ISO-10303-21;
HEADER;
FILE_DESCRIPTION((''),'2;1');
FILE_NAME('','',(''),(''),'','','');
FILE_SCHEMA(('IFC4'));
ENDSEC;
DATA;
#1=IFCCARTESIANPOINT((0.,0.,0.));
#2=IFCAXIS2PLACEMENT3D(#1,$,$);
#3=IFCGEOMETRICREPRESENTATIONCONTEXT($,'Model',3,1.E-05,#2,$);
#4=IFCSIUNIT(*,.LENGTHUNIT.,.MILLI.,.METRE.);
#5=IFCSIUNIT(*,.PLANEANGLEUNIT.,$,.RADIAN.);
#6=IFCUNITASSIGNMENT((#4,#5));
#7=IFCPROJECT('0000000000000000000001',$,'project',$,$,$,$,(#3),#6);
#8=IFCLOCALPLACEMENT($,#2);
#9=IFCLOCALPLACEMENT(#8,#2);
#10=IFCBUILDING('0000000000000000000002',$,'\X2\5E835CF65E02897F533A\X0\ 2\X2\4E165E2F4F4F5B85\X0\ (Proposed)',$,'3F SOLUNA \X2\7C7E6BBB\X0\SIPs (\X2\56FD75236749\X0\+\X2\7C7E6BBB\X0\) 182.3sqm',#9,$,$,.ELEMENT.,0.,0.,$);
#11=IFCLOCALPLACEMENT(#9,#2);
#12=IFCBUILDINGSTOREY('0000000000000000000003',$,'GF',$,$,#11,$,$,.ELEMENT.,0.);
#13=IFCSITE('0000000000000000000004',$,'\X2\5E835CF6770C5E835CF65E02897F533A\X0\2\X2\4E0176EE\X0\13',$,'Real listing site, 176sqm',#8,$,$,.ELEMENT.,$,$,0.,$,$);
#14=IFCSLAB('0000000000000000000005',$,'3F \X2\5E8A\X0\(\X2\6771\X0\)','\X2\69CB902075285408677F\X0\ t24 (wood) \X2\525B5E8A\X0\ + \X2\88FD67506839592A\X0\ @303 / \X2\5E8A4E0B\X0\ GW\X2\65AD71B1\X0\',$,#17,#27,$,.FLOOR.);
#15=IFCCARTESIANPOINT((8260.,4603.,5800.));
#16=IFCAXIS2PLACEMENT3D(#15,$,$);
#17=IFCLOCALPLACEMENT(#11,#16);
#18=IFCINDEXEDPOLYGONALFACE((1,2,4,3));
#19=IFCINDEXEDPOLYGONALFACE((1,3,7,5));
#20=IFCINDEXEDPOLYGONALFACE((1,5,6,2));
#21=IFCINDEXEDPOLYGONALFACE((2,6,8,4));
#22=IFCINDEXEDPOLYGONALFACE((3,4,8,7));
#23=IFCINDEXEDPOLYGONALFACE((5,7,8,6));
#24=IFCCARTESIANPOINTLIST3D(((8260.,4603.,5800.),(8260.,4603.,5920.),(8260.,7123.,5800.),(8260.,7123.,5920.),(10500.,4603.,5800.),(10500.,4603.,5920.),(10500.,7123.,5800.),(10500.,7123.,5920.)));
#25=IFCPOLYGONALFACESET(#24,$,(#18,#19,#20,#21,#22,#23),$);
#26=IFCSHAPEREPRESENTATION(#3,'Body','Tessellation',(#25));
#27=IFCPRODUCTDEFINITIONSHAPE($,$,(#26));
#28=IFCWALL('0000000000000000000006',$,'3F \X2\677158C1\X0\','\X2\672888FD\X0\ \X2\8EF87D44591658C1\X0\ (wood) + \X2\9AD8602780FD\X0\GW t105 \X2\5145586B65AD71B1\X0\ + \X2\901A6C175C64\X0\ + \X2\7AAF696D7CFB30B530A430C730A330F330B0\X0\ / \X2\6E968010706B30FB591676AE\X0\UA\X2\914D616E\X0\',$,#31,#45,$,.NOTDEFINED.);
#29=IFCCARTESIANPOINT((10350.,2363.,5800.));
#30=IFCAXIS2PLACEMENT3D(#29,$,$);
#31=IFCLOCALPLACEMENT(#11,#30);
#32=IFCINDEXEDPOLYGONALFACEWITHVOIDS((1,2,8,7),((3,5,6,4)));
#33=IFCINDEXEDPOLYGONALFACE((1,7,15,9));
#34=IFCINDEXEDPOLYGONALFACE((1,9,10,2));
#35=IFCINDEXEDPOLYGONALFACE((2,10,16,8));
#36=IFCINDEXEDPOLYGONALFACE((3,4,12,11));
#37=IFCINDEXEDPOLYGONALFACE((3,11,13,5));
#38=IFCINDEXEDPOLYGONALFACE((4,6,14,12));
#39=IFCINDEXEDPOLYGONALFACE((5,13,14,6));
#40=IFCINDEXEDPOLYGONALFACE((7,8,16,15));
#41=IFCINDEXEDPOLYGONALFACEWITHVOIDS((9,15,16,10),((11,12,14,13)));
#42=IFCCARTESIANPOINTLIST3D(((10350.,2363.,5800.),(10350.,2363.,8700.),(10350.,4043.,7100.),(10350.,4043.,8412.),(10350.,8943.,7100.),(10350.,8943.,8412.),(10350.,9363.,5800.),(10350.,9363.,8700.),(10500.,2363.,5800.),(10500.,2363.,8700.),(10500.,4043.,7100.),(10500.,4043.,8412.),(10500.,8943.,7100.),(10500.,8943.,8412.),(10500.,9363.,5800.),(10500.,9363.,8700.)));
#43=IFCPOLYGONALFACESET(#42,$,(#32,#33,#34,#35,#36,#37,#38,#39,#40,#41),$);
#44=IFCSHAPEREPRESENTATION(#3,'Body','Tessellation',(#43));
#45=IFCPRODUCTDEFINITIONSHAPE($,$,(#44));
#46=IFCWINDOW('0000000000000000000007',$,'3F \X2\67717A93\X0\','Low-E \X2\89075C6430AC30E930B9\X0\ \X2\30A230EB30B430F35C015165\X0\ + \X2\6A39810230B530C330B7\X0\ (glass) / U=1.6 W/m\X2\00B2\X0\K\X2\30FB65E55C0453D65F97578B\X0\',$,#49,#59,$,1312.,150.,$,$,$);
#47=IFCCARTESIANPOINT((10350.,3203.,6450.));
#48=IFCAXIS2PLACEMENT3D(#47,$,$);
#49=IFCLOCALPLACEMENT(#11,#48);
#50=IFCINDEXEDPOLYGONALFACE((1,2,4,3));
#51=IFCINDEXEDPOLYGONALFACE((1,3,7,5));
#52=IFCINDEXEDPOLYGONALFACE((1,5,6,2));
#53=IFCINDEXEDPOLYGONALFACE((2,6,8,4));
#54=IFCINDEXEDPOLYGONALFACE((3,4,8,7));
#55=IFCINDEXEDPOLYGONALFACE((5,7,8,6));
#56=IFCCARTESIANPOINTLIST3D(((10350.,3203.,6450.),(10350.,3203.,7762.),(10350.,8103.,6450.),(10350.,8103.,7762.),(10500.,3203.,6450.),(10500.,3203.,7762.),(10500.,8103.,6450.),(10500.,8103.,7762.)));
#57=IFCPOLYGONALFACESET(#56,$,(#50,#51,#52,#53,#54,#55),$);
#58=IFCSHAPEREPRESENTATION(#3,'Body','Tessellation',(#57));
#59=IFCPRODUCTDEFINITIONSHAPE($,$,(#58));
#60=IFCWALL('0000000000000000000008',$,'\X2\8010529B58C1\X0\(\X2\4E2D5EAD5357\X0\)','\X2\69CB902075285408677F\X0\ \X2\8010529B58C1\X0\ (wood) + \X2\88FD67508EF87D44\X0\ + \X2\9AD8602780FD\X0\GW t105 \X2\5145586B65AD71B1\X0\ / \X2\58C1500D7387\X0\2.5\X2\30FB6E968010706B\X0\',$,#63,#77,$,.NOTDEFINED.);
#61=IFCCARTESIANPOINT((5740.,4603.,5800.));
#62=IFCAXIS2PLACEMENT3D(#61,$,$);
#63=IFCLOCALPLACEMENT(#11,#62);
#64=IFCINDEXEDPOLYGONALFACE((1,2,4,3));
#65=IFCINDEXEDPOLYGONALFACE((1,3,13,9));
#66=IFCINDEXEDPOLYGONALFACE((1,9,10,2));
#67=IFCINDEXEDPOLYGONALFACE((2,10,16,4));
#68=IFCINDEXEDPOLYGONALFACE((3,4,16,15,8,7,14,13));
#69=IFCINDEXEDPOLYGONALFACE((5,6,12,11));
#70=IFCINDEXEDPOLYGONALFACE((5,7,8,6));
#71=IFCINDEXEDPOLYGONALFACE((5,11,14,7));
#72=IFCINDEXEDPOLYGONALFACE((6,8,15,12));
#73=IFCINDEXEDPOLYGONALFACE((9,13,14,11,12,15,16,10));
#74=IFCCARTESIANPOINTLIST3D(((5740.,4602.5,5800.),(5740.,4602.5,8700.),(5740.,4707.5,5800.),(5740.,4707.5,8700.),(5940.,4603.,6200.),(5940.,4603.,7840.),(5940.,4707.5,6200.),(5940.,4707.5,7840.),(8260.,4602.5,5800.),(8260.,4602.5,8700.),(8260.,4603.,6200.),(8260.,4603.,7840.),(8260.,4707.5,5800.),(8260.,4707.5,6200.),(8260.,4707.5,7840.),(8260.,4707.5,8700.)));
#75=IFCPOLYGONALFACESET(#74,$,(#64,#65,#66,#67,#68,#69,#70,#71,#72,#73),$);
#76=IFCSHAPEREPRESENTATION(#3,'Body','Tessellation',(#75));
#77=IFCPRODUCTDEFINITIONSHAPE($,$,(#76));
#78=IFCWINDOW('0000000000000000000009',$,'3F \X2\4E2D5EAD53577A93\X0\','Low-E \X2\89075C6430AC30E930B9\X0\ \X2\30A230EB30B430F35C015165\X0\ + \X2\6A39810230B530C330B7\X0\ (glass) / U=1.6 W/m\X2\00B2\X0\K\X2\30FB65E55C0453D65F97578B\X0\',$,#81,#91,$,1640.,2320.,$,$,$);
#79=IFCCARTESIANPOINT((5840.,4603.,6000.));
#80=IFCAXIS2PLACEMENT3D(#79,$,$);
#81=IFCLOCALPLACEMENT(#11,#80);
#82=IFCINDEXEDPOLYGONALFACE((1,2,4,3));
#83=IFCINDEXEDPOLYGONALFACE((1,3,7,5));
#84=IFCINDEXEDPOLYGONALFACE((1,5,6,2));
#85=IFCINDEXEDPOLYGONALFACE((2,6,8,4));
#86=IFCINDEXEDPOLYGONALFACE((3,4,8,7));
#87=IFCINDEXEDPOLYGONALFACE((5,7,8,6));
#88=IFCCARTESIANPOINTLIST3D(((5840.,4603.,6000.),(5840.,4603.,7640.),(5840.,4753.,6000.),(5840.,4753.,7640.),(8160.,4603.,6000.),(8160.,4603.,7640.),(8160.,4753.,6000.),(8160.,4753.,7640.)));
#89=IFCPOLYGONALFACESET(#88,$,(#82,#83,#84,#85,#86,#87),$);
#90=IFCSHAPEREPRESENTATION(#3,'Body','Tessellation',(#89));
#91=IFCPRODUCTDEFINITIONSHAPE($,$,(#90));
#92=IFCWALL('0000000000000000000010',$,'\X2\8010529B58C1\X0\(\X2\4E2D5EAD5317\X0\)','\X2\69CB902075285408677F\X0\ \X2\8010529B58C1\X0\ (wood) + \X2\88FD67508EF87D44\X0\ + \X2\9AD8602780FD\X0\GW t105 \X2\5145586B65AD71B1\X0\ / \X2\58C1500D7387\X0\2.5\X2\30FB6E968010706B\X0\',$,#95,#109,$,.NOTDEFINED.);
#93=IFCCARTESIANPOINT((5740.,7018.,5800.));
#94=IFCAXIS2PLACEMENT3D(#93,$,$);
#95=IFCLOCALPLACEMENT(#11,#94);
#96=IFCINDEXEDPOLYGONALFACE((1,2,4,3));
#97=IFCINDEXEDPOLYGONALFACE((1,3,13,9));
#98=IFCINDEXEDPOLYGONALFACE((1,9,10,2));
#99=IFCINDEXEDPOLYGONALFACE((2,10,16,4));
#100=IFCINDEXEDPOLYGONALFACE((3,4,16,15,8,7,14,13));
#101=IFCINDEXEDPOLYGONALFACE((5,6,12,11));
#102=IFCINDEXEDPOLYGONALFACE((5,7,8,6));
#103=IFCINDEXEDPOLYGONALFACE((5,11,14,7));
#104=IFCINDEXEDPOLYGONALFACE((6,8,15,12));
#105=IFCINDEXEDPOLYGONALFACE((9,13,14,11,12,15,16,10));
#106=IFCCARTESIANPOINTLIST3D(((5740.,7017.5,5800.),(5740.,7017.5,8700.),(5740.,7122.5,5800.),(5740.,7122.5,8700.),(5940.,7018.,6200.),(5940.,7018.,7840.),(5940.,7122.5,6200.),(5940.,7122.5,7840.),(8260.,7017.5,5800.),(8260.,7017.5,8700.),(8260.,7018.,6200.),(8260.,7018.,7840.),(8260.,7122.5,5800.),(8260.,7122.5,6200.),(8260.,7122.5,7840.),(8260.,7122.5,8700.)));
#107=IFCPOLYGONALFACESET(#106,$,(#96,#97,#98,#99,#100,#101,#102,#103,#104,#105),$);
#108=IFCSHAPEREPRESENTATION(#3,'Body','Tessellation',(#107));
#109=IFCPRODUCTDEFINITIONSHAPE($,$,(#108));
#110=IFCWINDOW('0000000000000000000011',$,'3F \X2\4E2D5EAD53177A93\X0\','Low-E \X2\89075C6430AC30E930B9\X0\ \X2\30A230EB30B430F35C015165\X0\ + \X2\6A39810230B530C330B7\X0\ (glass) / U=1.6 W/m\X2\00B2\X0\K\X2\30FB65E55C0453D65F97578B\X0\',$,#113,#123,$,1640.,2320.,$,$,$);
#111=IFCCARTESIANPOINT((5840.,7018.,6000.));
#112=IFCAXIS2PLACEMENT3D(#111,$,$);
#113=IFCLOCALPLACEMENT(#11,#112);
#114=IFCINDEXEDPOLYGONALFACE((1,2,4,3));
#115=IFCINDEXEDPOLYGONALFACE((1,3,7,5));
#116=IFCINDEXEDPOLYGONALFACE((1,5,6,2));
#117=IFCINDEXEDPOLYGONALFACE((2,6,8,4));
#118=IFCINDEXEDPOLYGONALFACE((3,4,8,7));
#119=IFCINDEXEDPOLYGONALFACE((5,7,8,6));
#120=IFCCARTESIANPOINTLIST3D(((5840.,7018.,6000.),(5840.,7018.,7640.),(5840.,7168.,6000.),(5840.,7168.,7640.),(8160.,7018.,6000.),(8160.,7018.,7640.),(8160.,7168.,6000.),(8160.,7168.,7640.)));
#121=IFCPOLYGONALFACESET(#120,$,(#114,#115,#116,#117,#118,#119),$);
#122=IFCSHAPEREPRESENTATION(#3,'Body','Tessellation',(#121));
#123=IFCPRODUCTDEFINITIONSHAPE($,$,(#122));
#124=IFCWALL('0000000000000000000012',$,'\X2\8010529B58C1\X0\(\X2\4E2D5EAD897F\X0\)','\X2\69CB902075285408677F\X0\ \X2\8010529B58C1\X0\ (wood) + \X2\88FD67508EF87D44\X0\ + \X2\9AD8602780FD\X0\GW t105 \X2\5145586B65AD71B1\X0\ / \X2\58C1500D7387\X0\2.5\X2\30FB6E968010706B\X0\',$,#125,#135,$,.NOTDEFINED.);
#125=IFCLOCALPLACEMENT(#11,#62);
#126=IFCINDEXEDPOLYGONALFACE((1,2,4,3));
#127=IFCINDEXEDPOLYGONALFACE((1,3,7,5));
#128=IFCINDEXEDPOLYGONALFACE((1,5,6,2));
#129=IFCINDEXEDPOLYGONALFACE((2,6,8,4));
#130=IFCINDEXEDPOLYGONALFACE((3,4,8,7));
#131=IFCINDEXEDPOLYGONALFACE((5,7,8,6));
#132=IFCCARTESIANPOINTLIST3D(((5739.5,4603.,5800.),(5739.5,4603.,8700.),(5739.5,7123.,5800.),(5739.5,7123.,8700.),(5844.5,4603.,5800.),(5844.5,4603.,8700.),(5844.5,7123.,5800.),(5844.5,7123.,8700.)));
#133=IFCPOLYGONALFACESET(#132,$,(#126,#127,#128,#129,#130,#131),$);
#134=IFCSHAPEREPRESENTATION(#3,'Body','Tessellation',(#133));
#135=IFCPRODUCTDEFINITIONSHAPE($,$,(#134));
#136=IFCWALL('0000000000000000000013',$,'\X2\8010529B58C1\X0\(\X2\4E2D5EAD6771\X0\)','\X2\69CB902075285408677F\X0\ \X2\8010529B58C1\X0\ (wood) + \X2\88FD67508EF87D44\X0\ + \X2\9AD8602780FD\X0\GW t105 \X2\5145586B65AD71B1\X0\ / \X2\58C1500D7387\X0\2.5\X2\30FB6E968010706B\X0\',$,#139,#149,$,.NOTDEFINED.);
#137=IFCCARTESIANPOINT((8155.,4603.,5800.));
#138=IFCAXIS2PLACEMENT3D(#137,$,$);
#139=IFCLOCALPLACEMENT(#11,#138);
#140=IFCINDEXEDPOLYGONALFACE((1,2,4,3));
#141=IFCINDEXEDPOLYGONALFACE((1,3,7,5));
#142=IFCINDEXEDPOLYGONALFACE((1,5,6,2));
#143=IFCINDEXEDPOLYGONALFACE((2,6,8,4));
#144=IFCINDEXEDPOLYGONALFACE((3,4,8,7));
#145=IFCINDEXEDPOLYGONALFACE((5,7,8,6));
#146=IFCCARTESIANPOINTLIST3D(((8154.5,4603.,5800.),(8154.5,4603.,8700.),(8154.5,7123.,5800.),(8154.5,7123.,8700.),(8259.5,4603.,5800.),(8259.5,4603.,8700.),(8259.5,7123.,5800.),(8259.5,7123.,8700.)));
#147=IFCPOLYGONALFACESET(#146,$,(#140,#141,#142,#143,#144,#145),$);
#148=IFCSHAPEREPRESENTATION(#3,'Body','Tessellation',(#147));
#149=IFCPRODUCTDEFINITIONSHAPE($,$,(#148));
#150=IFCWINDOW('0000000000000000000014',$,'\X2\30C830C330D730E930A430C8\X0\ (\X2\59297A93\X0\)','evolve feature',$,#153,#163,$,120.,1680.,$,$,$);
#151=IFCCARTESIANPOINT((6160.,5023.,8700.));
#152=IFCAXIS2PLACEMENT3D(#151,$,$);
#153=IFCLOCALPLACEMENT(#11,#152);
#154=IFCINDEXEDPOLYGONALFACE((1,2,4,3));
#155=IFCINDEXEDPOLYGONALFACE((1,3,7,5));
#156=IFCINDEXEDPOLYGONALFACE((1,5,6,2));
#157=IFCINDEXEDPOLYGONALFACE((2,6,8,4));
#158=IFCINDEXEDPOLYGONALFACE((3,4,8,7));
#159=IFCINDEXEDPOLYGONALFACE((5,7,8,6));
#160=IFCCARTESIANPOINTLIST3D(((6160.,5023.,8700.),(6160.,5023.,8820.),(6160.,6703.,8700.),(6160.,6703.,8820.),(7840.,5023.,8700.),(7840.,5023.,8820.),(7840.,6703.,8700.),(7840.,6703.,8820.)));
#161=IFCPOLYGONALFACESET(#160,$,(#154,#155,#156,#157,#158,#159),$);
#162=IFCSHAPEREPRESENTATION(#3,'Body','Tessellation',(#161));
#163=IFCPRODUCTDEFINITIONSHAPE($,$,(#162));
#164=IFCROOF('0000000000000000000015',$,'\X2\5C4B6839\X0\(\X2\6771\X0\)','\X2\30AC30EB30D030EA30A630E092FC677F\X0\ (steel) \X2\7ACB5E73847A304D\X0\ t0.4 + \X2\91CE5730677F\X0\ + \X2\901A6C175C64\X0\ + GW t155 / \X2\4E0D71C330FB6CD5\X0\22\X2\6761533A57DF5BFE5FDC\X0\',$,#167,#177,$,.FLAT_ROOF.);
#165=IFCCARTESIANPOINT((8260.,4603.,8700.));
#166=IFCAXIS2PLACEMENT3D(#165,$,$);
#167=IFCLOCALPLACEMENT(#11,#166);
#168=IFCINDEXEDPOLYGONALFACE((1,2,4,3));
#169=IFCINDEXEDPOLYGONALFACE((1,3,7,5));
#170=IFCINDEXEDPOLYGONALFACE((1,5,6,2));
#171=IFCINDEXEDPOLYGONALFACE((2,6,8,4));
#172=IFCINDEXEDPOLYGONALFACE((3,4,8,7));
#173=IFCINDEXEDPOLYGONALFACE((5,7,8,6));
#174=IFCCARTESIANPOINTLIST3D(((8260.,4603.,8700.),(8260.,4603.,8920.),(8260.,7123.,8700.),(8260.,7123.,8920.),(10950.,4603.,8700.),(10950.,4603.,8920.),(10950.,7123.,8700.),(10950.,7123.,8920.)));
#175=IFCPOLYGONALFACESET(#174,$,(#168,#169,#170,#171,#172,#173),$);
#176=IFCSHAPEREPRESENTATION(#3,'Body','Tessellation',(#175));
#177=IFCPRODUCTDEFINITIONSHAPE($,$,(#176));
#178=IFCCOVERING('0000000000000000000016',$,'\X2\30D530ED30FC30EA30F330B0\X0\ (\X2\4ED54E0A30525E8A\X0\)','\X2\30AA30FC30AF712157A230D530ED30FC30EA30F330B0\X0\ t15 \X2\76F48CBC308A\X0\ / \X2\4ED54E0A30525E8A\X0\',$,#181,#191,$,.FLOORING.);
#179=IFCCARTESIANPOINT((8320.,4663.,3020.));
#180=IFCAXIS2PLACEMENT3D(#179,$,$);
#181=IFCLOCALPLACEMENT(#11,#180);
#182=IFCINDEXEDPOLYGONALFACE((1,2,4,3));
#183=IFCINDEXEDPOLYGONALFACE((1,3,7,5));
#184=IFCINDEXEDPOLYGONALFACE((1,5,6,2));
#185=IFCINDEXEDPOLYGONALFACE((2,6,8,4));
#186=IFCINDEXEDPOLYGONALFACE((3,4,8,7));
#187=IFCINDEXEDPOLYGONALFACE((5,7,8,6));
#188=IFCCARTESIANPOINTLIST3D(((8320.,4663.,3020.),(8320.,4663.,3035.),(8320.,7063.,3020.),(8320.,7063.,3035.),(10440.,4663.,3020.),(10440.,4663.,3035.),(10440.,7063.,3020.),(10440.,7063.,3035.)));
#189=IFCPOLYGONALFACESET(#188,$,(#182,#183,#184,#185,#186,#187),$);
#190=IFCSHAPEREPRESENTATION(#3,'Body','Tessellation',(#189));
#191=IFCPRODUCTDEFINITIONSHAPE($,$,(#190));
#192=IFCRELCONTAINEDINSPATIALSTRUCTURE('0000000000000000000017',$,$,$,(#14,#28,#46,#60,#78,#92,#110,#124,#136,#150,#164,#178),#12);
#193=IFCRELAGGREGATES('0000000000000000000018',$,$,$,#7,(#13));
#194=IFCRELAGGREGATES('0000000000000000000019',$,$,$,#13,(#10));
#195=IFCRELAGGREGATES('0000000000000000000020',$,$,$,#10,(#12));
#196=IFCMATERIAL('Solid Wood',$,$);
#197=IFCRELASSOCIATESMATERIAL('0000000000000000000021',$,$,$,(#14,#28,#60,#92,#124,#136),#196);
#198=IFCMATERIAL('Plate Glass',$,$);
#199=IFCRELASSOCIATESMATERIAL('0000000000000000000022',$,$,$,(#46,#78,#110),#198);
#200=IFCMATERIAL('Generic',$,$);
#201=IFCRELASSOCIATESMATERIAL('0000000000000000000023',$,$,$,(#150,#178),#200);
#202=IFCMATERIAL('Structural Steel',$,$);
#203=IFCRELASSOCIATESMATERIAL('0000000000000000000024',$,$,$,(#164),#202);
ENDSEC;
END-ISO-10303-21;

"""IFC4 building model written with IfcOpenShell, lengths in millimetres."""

from ifc_helpers import new_model, si_unit, frame, frame_2d, origin, place, context, project, spatial, rectangle, extrude, material, element, fill, save


model = new_model("IFC4")

# Units and contexts
model_context = context("Model", 3, precision=1e-05, world=origin())
ifc_project = project(units=[si_unit("LENGTHUNIT", "METRE", prefix="MILLI"), si_unit("PLANEANGLEUNIT", "RADIAN")], contexts=[model_context])

# Site, building, storey
site_placement = place(None, origin())
site = spatial("IfcSite", under=ifc_project, at=site_placement, Name="広島県広島市西区2丁目13", ObjectType="Real listing site, 176sqm", CompositionType="ELEMENT", RefElevation=0.0)
building_placement = place(site_placement, origin())
building = spatial("IfcBuilding", under=site, at=building_placement, Name="広島市西区 2世帯住宅 (Proposed)", ObjectType="3F SOLUNA 籾殻SIPs (国産杉+籾殻) 182.3sqm", CompositionType="ELEMENT", ElevationOfRefHeight=0.0, ElevationOfTerrain=0.0)
storey_placement = place(building_placement, origin())
storey = spatial("IfcBuildingStorey", under=building, at=storey_placement, Name="GF", CompositionType="ELEMENT", Elevation=0.0)

# Slab
ifc_material_1 = material(Name="Solid Wood")
slab_placement = place(storey_placement, frame((8260.0, 4603.0, 5800.0)))
element("IfcSlab", 1, at=slab_placement, inside=storey, material=ifc_material_1, Name="3F 床(東)", Description="構造用合板 t24 (wood) 剛床 + 製材根太 @303 / 床下 GW断熱", PredefinedType="FLOOR", context=model_context, shape_type="SweptSolid", body=[
    extrude(rectangle(XDim=2240.0, YDim=2520.0, at=frame_2d((1120.0, 1260.0))), frame((8260.0, 4603.0, 5800.0)), (0.0, 0.0, 1.0), 120.0),
])

# Walls, openings, windows
wall_1_placement = place(storey_placement, frame((10350.0, 2363.0, 5800.0)))
wall_1 = element("IfcWall", 2, at=wall_1_placement, inside=storey, material=ifc_material_1, Name="3F 東壁", Description="木製 軸組外壁 (wood) + 高性能GW t105 充填断熱 + 通気層 + 窯業系サイディング / 準耐火・外皮UA配慮", PredefinedType="NOTDEFINED", context=model_context, shape_type="SweptSolid", body=[
    extrude(rectangle(XDim=150.0, YDim=7000.0, at=frame_2d((75.0, 3500.0))), frame((10350.0, 2363.0, 5800.0)), (0.0, 0.0, 1.0), 2900.0),
])
opening_1_placement = place(storey_placement, frame((10350.0, 3203.0, 6450.0)))
opening_1 = element("IfcOpeningElement", 3, at=opening_1_placement, cuts=wall_1, PredefinedType="NOTDEFINED", context=model_context, shape_type="SweptSolid", body=[
    extrude(rectangle(XDim=150.0, YDim=4900.0, at=frame_2d((75.0, 2450.0))), frame((10350.0, 3203.0, 6450.0)), (0.0, 0.0, 1.0), 1312.0),
])
ifc_material_2 = material(Name="Plate Glass")
window_1_placement = place(storey_placement, frame((10350.0, 3203.0, 6450.0)))
window_1 = element("IfcWindow", 4, at=window_1_placement, inside=storey, material=ifc_material_2, Name="3F 東窓", Description="Low-E 複層ガラス アルゴン封入 + 樹脂サッシ (glass) / U=1.6 W/m²K・日射取得型", OverallHeight=1312.0, OverallWidth=150.0, context=model_context, shape_type="SweptSolid", body=[
    extrude(rectangle(XDim=150.0, YDim=4900.0, at=frame_2d((75.0, 2450.0))), frame((10350.0, 3203.0, 6450.0)), (0.0, 0.0, 1.0), 1312.0),
])
fill(opening_1, window_1)
wall_2_placement = place(storey_placement, frame((5740.0, 4603.0, 5800.0)))
wall_2 = element("IfcWall", 5, at=wall_2_placement, inside=storey, material=ifc_material_1, Name="耐力壁(中庭南)", Description="構造用合板 耐力壁 (wood) + 製材軸組 + 高性能GW t105 充填断熱 / 壁倍率2.5・準耐火", PredefinedType="NOTDEFINED", context=model_context, shape_type="SweptSolid", body=[
    extrude(rectangle(XDim=2520.0, YDim=105.0, at=frame_2d((1260.0, 52.0))), frame((5740.0, 4603.0, 5800.0)), (0.0, 0.0, 1.0), 2900.0),
])
opening_2_placement = place(storey_placement, frame((5840.0, 4603.0, 6000.0)))
opening_2 = element("IfcOpeningElement", 6, at=opening_2_placement, cuts=wall_2, PredefinedType="NOTDEFINED", context=model_context, shape_type="SweptSolid", body=[
    extrude(rectangle(XDim=2320.0, YDim=150.0, at=frame_2d((1160.0, 75.0))), frame((5840.0, 4603.0, 6000.0)), (0.0, 0.0, 1.0), 1640.0),
])
window_2_placement = place(storey_placement, frame((5840.0, 4603.0, 6000.0)))
window_2 = element("IfcWindow", 7, at=window_2_placement, inside=storey, material=ifc_material_2, Name="3F 中庭南窓", Description="Low-E 複層ガラス アルゴン封入 + 樹脂サッシ (glass) / U=1.6 W/m²K・日射取得型", OverallHeight=1640.0, OverallWidth=2320.0, context=model_context, shape_type="SweptSolid", body=[
    extrude(rectangle(XDim=2320.0, YDim=150.0, at=frame_2d((1160.0, 75.0))), frame((5840.0, 4603.0, 6000.0)), (0.0, 0.0, 1.0), 1640.0),
])
fill(opening_2, window_2)
wall_3_placement = place(storey_placement, frame((5740.0, 7018.0, 5800.0)))
wall_3 = element("IfcWall", 8, at=wall_3_placement, inside=storey, material=ifc_material_1, Name="耐力壁(中庭北)", Description="構造用合板 耐力壁 (wood) + 製材軸組 + 高性能GW t105 充填断熱 / 壁倍率2.5・準耐火", PredefinedType="NOTDEFINED", context=model_context, shape_type="SweptSolid", body=[
    extrude(rectangle(XDim=2520.0, YDim=105.0, at=frame_2d((1260.0, 52.0))), frame((5740.0, 7018.0, 5800.0)), (0.0, 0.0, 1.0), 2900.0),
])
opening_3_placement = place(storey_placement, frame((5840.0, 7018.0, 6000.0)))
opening_3 = element("IfcOpeningElement", 9, at=opening_3_placement, cuts=wall_3, PredefinedType="NOTDEFINED", context=model_context, shape_type="SweptSolid", body=[
    extrude(rectangle(XDim=2320.0, YDim=150.0, at=frame_2d((1160.0, 75.0))), frame((5840.0, 7018.0, 6000.0)), (0.0, 0.0, 1.0), 1640.0),
])
window_3_placement = place(storey_placement, frame((5840.0, 7018.0, 6000.0)))
window_3 = element("IfcWindow", 10, at=window_3_placement, inside=storey, material=ifc_material_2, Name="3F 中庭北窓", Description="Low-E 複層ガラス アルゴン封入 + 樹脂サッシ (glass) / U=1.6 W/m²K・日射取得型", OverallHeight=1640.0, OverallWidth=2320.0, context=model_context, shape_type="SweptSolid", body=[
    extrude(rectangle(XDim=2320.0, YDim=150.0, at=frame_2d((1160.0, 75.0))), frame((5840.0, 7018.0, 6000.0)), (0.0, 0.0, 1.0), 1640.0),
])
fill(opening_3, window_3)

# Walls
wall_4_placement = place(storey_placement, frame((5740.0, 4603.0, 5800.0)))
element("IfcWall", 11, at=wall_4_placement, inside=storey, material=ifc_material_1, Name="耐力壁(中庭西)", Description="構造用合板 耐力壁 (wood) + 製材軸組 + 高性能GW t105 充填断熱 / 壁倍率2.5・準耐火", PredefinedType="NOTDEFINED", context=model_context, shape_type="SweptSolid", body=[
    extrude(rectangle(XDim=105.0, YDim=2520.0, at=frame_2d((52.0, 1260.0))), frame((5740.0, 4603.0, 5800.0)), (0.0, 0.0, 1.0), 2900.0),
])
wall_5_placement = place(storey_placement, frame((8155.0, 4603.0, 5800.0)))
element("IfcWall", 12, at=wall_5_placement, inside=storey, material=ifc_material_1, Name="耐力壁(中庭東)", Description="構造用合板 耐力壁 (wood) + 製材軸組 + 高性能GW t105 充填断熱 / 壁倍率2.5・準耐火", PredefinedType="NOTDEFINED", context=model_context, shape_type="SweptSolid", body=[
    extrude(rectangle(XDim=105.0, YDim=2520.0, at=frame_2d((52.0, 1260.0))), frame((8155.0, 4603.0, 5800.0)), (0.0, 0.0, 1.0), 2900.0),
])

# Window
ifc_material_3 = material(Name="Generic")
window_4_placement = place(storey_placement, frame((6160.0, 5023.0, 8700.0)))
element("IfcWindow", 13, at=window_4_placement, inside=storey, material=ifc_material_3, Name="トップライト (天窓)", Description="evolve feature", OverallHeight=120.0, OverallWidth=1680.0, context=model_context, shape_type="SweptSolid", body=[
    extrude(rectangle(XDim=1680.0, YDim=1680.0, at=frame_2d((840.0, 840.0))), frame((6160.0, 5023.0, 8700.0)), (0.0, 0.0, 1.0), 120.0),
])

# Roof
ifc_material_4 = material(Name="Structural Steel")
for number, where, name in (
    (14, (8260.0, 4603.0, 8700.0), "屋根(東)"),
):
    element("IfcRoof", number, at=place(storey_placement, frame(where)), inside=storey, material=ifc_material_4, Name=name, Description="ガルバリウム鋼板 (steel) 立平葺き t0.4 + 野地板 + 通気層 + GW t155 / 不燃・法22条区域対応", PredefinedType="FLAT_ROOF", context=model_context, shape_type="SweptSolid", body=[
        extrude(rectangle(XDim=2690.0, YDim=2520.0, at=frame_2d((1345.0, 1260.0))), frame((8260.0, 4603.0, 8700.0)), (0.0, 0.0, 1.0), 220.0),
    ])

# Covering
covering_1_placement = place(storey_placement, frame((8320.0, 4663.0, 3020.0)))
element("IfcCovering", 15, at=covering_1_placement, inside=storey, material=ifc_material_3, Name="フローリング (仕上げ床)", Description="オーク無垢フローリング t15 直貼り / 仕上げ床", PredefinedType="FLOORING", context=model_context, shape_type="SweptSolid", body=[
    extrude(rectangle(XDim=2120.0, YDim=2400.0, at=frame_2d((1060.0, 1200.0))), frame((8320.0, 4663.0, 3020.0)), (0.0, 0.0, 1.0), 15.0),
])

save(model, "model.ifc")
